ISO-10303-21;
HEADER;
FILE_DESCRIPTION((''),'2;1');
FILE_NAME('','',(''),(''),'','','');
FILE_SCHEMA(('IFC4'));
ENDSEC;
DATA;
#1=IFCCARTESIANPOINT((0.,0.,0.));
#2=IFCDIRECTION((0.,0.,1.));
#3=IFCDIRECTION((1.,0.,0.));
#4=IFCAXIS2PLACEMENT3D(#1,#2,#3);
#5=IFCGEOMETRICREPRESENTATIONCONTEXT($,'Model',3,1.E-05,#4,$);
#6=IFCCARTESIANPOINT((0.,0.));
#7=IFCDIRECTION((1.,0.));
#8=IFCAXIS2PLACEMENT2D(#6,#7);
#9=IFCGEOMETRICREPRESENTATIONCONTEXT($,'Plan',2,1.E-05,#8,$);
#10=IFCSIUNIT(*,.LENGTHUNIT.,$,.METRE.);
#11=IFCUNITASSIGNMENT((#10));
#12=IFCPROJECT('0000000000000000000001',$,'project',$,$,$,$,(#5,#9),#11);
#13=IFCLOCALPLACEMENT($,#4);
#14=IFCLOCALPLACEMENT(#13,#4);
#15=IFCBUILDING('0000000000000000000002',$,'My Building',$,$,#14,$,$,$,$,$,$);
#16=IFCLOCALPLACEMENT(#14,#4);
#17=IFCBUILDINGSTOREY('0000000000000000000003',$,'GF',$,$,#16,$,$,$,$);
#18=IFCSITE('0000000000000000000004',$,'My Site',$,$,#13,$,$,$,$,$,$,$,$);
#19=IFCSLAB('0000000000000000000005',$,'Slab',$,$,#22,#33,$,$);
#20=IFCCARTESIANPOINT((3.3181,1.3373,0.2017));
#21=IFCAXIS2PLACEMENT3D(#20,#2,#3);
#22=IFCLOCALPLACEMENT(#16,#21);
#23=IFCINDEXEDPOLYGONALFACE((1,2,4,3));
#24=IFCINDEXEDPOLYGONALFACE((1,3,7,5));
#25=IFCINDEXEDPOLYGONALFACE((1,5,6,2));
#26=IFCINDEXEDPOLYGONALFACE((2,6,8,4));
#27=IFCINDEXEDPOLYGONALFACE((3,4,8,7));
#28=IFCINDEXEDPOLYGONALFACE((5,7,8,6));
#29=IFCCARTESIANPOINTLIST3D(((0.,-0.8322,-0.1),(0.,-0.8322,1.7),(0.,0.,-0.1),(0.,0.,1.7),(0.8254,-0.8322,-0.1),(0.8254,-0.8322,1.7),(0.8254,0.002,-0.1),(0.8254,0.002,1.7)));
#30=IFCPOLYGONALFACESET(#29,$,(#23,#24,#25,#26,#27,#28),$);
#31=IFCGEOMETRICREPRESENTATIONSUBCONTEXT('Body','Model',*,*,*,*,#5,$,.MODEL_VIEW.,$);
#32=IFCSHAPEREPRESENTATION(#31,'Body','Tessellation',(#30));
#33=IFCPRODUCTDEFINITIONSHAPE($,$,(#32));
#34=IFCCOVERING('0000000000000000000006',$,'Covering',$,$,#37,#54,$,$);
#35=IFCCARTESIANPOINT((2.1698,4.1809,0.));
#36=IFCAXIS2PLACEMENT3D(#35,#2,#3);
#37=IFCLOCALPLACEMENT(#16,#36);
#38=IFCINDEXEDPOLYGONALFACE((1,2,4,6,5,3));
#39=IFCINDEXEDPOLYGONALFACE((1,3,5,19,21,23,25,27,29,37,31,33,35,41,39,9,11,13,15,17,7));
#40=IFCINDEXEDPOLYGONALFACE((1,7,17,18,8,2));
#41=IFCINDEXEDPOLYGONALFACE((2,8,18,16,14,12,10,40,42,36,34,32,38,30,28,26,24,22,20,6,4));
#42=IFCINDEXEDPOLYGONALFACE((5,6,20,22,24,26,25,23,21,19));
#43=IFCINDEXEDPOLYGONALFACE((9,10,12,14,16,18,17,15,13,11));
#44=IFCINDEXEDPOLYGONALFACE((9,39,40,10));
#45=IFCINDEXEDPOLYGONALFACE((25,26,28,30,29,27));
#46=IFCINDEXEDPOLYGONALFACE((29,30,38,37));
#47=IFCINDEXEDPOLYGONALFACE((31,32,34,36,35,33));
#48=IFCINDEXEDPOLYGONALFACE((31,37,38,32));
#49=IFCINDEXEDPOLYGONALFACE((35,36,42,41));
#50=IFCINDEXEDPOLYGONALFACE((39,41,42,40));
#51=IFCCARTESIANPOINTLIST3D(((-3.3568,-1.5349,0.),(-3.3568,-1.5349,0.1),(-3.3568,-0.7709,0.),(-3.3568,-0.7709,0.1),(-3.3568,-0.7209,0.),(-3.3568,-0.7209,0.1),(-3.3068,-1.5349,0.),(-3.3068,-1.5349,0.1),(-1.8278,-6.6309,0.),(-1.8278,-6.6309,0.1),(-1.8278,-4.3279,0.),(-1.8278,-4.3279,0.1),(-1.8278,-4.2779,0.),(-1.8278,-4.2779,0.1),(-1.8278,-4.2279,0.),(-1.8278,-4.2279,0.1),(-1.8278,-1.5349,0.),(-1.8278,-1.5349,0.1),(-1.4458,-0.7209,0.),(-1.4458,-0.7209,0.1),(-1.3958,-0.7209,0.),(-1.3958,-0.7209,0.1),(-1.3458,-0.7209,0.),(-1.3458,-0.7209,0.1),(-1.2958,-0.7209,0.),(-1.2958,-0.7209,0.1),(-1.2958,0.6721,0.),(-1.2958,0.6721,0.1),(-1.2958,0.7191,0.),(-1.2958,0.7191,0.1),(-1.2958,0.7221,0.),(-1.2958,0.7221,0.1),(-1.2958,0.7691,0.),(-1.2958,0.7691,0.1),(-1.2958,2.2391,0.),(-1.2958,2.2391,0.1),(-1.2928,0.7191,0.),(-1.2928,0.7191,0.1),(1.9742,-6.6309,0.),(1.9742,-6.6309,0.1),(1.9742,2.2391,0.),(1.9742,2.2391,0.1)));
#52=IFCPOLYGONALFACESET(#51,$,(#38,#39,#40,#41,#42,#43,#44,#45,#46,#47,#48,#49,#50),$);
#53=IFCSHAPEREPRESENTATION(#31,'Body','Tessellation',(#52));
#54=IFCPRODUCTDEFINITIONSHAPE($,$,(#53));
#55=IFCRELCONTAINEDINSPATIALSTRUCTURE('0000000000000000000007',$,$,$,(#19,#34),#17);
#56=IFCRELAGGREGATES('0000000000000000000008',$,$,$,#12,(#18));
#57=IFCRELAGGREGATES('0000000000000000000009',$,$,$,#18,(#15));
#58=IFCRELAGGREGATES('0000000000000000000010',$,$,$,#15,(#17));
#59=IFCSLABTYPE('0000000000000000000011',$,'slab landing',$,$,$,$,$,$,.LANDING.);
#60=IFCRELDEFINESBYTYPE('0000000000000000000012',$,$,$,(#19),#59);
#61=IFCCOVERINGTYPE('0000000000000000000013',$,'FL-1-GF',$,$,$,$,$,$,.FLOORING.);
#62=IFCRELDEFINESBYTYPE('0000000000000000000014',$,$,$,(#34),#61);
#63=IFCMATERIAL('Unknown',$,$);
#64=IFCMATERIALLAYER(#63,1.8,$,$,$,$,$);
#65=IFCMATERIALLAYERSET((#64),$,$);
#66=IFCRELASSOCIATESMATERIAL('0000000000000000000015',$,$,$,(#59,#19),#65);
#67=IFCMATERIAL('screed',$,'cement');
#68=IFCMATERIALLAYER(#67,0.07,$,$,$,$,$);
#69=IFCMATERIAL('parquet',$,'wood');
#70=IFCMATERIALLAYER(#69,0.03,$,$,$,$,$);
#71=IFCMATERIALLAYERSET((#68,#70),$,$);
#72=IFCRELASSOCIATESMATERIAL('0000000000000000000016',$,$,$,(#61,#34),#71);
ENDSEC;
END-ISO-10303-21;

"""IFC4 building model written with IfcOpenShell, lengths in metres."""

from ifc_helpers import new_model, si_unit, frame, origin_with_axes, origin_2d_with_axis, place, context, subcontext, project, spatial, line, indexed_curve, outline, extrude, material, layer, layer_set, layer_usage, type_object, element, save


model = new_model("IFC4")

# Units and contexts
model_context = context("Model", 3, precision=1e-05, world=origin_with_axes())
plan_context = context("Plan", 2, precision=1e-05, world=origin_2d_with_axis())
body_context_1 = subcontext(model_context, "Body", "Model", "MODEL_VIEW")
ifc_project = project(units=[si_unit("LENGTHUNIT", "METRE")], contexts=[model_context, plan_context])

# Site, building, storey
site_placement = place(None, origin_with_axes())
site = spatial("IfcSite", under=ifc_project, at=site_placement, Name="My Site")
building_placement = place(site_placement, origin_with_axes())
building = spatial("IfcBuilding", under=site, at=building_placement, Name="My Building")
storey_placement = place(building_placement, origin_with_axes())
storey = spatial("IfcBuildingStorey", under=building, at=storey_placement, Name="GF")

# Slab
ifc_material_1 = material(Name="Unknown")
ifc_layer_1 = layer(ifc_material_1, 1.8)
ifc_layer_set_1 = layer_set([ifc_layer_1])
ifc_layer_usage_1 = layer_usage(ifc_layer_set_1, "AXIS3", "POSITIVE", -0.1)
slab_type_1 = type_object("IfcSlabType", Name="slab landing", PredefinedType="LANDING", material=ifc_layer_set_1)
slab_1_placement = place(storey_placement, frame((3.3181, 1.3373, 0.2017), z_axis=(0.0, 0.0, 1.0), x_axis=(1.0, 0.0, 0.0)))
element("IfcSlab", 1, at=slab_1_placement, inside=storey, type_object=slab_type_1, material=ifc_layer_usage_1, Name="Slab", context=body_context_1, shape_type="SweptSolid", body=[
    extrude(outline(indexed_curve([(0.0, 0.0), (0.0, -0.8322), (0.8254, -0.8322), (0.8254, 0.002), (0.0, 0.0)])), frame((0.0, 0.0, -0.1), z_axis=(0.0, 0.0, 1.0), x_axis=(1.0, 0.0, 0.0)), (0.0, 0.0, 1.0), 1.8),
])

# Covering
ifc_material_2 = material(Name="screed", Category="cement")
ifc_layer_2 = layer(ifc_material_2, 0.07)
ifc_material_3 = material(Name="parquet", Category="wood")
ifc_layer_3 = layer(ifc_material_3, 0.03)
ifc_layer_set_2 = layer_set([ifc_layer_2, ifc_layer_3])
ifc_layer_usage_2 = layer_usage(ifc_layer_set_2, "AXIS3", "POSITIVE", 0.0)
covering_type = type_object("IfcCoveringType", Name="FL-1-GF", PredefinedType="FLOORING", material=ifc_layer_set_2)
covering_placement = place(storey_placement, frame((2.1698, 4.1809, 0.0), z_axis=(0.0, 0.0, 1.0), x_axis=(1.0, 0.0, 0.0)))
element("IfcCovering", 2, at=covering_placement, inside=storey, type_object=covering_type, material=ifc_layer_usage_2, Name="Covering", context=body_context_1, shape_type="SweptSolid", body=[
    extrude(outline(indexed_curve([(-1.4458, -0.7209), (-1.3958, -0.7209), (-1.3458, -0.7209), (-1.2958, -0.7209), (-1.2958, 0.6721), (-1.2958, 0.7191), (-1.2928, 0.7191), (-1.2958, 0.7221), (-1.2958, 0.7221), (-1.2958, 0.7691), (-1.2958, 2.2391), (1.9742, 2.2391), (1.9742, -6.6309), (-1.8278, -6.6309), (-1.8278, -4.3279), (-1.8278, -4.2779), (-1.8278, -4.2779), (-1.8278, -4.2279), (-1.8278, -1.5349), (-3.3068, -1.5349), (-3.3568, -1.5349), (-3.3568, -0.7709), (-3.3568, -0.7209)], segments=[line(1, 2, 3, 4, 5, 6, 7, 8, 9, 10, 11, 12, 13, 14, 15, 16, 17, 18, 19, 20, 21, 22, 23, 1)])), origin_with_axes(), (0.0, 0.0, 1.0), 0.1),
])

save(model, "model.ifc")
